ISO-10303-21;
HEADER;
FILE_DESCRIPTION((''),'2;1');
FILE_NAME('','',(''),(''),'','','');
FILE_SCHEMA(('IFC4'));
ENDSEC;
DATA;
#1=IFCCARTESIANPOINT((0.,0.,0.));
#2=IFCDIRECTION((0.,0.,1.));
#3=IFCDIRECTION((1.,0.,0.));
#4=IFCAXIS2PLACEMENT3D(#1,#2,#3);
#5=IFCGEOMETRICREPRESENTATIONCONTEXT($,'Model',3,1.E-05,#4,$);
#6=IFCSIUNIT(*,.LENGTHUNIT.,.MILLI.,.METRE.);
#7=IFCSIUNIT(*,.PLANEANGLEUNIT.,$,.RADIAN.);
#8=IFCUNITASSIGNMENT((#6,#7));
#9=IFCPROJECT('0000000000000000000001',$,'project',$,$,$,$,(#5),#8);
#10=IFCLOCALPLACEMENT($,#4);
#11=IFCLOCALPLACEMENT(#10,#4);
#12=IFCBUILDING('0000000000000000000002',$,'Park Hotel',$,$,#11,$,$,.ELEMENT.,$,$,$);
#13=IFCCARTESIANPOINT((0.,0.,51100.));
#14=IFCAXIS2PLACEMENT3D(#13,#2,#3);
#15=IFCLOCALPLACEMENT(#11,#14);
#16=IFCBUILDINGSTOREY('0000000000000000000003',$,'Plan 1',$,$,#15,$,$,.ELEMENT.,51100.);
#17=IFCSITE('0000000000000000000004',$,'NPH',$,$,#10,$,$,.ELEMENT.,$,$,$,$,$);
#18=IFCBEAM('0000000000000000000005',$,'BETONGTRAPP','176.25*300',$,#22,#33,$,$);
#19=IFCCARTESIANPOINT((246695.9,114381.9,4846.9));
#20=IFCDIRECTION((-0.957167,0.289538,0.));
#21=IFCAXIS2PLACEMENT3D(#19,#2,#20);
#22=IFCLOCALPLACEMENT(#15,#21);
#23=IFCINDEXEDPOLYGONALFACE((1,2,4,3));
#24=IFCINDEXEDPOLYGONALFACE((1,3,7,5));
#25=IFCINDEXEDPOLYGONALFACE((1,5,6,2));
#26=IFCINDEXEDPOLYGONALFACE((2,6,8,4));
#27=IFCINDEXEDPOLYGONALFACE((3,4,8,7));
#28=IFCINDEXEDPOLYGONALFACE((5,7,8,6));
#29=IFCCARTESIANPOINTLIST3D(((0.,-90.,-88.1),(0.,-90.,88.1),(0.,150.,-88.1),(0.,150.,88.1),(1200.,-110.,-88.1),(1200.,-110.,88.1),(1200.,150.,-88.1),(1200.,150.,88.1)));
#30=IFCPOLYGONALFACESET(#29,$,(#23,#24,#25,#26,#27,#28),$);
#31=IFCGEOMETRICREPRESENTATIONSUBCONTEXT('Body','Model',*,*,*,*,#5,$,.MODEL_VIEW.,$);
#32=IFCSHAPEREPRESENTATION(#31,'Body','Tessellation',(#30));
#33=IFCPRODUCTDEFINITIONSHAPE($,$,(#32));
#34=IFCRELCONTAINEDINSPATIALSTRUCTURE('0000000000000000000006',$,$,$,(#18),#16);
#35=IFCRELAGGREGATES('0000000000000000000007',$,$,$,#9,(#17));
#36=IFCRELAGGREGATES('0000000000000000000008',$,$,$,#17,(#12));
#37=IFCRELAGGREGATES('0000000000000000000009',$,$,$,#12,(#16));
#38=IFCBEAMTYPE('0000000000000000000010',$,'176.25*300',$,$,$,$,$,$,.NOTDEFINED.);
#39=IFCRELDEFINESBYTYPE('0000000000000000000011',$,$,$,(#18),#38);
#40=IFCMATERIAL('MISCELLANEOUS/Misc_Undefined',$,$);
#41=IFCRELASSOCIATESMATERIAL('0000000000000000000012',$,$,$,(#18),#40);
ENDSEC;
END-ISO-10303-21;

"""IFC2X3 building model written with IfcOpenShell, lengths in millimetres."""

from ifc_helpers import new_model, si_unit, frame, origin_with_axes, origin_2d_with_axis, place, context, subcontext, project, spatial, rectangle, extrude, clip, halfspace, material, type_object, element, save


model = new_model("IFC2X3")

# Units and contexts
model_context = context("Model", 3, precision=1e-05, world=origin_with_axes())
body_context = subcontext(model_context, "Body", "Model", "MODEL_VIEW")
ifc_project = project(units=[si_unit("LENGTHUNIT", "METRE", prefix="MILLI"), si_unit("PLANEANGLEUNIT", "RADIAN")], contexts=[model_context])

# Site, building, storey
site_placement = place(None, origin_with_axes())
site = spatial("IfcSite", under=ifc_project, at=site_placement, Name="NPH", CompositionType="ELEMENT")
building_placement = place(site_placement, origin_with_axes())
building = spatial("IfcBuilding", under=site, at=building_placement, Name="Park Hotel", CompositionType="ELEMENT")
storey_placement = place(building_placement, frame((0.0, 0.0, 51100.0), z_axis=(0.0, 0.0, 1.0), x_axis=(1.0, 0.0, 0.0)))
storey = spatial("IfcBuildingStorey", under=building, at=storey_placement, Name="Plan 1", CompositionType="ELEMENT", Elevation=51100.0)

# Beam
ifc_material_1 = material(Name="MISCELLANEOUS/Misc_Undefined")
beam_type_1 = type_object("IfcBeamType", Name="176.25*300", PredefinedType="NOTDEFINED")
beam_1_placement = place(storey_placement, frame((246695.9, 114381.9, 4846.9), z_axis=(0.0, 0.0, 1.0), x_axis=(-0.957167, 0.289538, 0.0)))
element("IfcBeam", 1, at=beam_1_placement, inside=storey, type_object=beam_type_1, material=ifc_material_1, Name="BETONGTRAPP", Description="176.25*300", context=body_context, shape_type="Clipping", body=[
    clip(extrude(rectangle(XDim=300.0, YDim=176.2, at=origin_2d_with_axis()), frame((1200.0, 0.0, 0.0), z_axis=(-1.0, 0.0, 0.0), x_axis=(0.0, -1.0, 0.0)), (0.0, 0.0, 1.0), 1200.0), halfspace(frame((0.0, -90.0, -88.1), z_axis=(-0.016664, -0.999861, 0.0), x_axis=(0.0, 0.0, 1.0)), False)),
])

save(model, "model.ifc")
